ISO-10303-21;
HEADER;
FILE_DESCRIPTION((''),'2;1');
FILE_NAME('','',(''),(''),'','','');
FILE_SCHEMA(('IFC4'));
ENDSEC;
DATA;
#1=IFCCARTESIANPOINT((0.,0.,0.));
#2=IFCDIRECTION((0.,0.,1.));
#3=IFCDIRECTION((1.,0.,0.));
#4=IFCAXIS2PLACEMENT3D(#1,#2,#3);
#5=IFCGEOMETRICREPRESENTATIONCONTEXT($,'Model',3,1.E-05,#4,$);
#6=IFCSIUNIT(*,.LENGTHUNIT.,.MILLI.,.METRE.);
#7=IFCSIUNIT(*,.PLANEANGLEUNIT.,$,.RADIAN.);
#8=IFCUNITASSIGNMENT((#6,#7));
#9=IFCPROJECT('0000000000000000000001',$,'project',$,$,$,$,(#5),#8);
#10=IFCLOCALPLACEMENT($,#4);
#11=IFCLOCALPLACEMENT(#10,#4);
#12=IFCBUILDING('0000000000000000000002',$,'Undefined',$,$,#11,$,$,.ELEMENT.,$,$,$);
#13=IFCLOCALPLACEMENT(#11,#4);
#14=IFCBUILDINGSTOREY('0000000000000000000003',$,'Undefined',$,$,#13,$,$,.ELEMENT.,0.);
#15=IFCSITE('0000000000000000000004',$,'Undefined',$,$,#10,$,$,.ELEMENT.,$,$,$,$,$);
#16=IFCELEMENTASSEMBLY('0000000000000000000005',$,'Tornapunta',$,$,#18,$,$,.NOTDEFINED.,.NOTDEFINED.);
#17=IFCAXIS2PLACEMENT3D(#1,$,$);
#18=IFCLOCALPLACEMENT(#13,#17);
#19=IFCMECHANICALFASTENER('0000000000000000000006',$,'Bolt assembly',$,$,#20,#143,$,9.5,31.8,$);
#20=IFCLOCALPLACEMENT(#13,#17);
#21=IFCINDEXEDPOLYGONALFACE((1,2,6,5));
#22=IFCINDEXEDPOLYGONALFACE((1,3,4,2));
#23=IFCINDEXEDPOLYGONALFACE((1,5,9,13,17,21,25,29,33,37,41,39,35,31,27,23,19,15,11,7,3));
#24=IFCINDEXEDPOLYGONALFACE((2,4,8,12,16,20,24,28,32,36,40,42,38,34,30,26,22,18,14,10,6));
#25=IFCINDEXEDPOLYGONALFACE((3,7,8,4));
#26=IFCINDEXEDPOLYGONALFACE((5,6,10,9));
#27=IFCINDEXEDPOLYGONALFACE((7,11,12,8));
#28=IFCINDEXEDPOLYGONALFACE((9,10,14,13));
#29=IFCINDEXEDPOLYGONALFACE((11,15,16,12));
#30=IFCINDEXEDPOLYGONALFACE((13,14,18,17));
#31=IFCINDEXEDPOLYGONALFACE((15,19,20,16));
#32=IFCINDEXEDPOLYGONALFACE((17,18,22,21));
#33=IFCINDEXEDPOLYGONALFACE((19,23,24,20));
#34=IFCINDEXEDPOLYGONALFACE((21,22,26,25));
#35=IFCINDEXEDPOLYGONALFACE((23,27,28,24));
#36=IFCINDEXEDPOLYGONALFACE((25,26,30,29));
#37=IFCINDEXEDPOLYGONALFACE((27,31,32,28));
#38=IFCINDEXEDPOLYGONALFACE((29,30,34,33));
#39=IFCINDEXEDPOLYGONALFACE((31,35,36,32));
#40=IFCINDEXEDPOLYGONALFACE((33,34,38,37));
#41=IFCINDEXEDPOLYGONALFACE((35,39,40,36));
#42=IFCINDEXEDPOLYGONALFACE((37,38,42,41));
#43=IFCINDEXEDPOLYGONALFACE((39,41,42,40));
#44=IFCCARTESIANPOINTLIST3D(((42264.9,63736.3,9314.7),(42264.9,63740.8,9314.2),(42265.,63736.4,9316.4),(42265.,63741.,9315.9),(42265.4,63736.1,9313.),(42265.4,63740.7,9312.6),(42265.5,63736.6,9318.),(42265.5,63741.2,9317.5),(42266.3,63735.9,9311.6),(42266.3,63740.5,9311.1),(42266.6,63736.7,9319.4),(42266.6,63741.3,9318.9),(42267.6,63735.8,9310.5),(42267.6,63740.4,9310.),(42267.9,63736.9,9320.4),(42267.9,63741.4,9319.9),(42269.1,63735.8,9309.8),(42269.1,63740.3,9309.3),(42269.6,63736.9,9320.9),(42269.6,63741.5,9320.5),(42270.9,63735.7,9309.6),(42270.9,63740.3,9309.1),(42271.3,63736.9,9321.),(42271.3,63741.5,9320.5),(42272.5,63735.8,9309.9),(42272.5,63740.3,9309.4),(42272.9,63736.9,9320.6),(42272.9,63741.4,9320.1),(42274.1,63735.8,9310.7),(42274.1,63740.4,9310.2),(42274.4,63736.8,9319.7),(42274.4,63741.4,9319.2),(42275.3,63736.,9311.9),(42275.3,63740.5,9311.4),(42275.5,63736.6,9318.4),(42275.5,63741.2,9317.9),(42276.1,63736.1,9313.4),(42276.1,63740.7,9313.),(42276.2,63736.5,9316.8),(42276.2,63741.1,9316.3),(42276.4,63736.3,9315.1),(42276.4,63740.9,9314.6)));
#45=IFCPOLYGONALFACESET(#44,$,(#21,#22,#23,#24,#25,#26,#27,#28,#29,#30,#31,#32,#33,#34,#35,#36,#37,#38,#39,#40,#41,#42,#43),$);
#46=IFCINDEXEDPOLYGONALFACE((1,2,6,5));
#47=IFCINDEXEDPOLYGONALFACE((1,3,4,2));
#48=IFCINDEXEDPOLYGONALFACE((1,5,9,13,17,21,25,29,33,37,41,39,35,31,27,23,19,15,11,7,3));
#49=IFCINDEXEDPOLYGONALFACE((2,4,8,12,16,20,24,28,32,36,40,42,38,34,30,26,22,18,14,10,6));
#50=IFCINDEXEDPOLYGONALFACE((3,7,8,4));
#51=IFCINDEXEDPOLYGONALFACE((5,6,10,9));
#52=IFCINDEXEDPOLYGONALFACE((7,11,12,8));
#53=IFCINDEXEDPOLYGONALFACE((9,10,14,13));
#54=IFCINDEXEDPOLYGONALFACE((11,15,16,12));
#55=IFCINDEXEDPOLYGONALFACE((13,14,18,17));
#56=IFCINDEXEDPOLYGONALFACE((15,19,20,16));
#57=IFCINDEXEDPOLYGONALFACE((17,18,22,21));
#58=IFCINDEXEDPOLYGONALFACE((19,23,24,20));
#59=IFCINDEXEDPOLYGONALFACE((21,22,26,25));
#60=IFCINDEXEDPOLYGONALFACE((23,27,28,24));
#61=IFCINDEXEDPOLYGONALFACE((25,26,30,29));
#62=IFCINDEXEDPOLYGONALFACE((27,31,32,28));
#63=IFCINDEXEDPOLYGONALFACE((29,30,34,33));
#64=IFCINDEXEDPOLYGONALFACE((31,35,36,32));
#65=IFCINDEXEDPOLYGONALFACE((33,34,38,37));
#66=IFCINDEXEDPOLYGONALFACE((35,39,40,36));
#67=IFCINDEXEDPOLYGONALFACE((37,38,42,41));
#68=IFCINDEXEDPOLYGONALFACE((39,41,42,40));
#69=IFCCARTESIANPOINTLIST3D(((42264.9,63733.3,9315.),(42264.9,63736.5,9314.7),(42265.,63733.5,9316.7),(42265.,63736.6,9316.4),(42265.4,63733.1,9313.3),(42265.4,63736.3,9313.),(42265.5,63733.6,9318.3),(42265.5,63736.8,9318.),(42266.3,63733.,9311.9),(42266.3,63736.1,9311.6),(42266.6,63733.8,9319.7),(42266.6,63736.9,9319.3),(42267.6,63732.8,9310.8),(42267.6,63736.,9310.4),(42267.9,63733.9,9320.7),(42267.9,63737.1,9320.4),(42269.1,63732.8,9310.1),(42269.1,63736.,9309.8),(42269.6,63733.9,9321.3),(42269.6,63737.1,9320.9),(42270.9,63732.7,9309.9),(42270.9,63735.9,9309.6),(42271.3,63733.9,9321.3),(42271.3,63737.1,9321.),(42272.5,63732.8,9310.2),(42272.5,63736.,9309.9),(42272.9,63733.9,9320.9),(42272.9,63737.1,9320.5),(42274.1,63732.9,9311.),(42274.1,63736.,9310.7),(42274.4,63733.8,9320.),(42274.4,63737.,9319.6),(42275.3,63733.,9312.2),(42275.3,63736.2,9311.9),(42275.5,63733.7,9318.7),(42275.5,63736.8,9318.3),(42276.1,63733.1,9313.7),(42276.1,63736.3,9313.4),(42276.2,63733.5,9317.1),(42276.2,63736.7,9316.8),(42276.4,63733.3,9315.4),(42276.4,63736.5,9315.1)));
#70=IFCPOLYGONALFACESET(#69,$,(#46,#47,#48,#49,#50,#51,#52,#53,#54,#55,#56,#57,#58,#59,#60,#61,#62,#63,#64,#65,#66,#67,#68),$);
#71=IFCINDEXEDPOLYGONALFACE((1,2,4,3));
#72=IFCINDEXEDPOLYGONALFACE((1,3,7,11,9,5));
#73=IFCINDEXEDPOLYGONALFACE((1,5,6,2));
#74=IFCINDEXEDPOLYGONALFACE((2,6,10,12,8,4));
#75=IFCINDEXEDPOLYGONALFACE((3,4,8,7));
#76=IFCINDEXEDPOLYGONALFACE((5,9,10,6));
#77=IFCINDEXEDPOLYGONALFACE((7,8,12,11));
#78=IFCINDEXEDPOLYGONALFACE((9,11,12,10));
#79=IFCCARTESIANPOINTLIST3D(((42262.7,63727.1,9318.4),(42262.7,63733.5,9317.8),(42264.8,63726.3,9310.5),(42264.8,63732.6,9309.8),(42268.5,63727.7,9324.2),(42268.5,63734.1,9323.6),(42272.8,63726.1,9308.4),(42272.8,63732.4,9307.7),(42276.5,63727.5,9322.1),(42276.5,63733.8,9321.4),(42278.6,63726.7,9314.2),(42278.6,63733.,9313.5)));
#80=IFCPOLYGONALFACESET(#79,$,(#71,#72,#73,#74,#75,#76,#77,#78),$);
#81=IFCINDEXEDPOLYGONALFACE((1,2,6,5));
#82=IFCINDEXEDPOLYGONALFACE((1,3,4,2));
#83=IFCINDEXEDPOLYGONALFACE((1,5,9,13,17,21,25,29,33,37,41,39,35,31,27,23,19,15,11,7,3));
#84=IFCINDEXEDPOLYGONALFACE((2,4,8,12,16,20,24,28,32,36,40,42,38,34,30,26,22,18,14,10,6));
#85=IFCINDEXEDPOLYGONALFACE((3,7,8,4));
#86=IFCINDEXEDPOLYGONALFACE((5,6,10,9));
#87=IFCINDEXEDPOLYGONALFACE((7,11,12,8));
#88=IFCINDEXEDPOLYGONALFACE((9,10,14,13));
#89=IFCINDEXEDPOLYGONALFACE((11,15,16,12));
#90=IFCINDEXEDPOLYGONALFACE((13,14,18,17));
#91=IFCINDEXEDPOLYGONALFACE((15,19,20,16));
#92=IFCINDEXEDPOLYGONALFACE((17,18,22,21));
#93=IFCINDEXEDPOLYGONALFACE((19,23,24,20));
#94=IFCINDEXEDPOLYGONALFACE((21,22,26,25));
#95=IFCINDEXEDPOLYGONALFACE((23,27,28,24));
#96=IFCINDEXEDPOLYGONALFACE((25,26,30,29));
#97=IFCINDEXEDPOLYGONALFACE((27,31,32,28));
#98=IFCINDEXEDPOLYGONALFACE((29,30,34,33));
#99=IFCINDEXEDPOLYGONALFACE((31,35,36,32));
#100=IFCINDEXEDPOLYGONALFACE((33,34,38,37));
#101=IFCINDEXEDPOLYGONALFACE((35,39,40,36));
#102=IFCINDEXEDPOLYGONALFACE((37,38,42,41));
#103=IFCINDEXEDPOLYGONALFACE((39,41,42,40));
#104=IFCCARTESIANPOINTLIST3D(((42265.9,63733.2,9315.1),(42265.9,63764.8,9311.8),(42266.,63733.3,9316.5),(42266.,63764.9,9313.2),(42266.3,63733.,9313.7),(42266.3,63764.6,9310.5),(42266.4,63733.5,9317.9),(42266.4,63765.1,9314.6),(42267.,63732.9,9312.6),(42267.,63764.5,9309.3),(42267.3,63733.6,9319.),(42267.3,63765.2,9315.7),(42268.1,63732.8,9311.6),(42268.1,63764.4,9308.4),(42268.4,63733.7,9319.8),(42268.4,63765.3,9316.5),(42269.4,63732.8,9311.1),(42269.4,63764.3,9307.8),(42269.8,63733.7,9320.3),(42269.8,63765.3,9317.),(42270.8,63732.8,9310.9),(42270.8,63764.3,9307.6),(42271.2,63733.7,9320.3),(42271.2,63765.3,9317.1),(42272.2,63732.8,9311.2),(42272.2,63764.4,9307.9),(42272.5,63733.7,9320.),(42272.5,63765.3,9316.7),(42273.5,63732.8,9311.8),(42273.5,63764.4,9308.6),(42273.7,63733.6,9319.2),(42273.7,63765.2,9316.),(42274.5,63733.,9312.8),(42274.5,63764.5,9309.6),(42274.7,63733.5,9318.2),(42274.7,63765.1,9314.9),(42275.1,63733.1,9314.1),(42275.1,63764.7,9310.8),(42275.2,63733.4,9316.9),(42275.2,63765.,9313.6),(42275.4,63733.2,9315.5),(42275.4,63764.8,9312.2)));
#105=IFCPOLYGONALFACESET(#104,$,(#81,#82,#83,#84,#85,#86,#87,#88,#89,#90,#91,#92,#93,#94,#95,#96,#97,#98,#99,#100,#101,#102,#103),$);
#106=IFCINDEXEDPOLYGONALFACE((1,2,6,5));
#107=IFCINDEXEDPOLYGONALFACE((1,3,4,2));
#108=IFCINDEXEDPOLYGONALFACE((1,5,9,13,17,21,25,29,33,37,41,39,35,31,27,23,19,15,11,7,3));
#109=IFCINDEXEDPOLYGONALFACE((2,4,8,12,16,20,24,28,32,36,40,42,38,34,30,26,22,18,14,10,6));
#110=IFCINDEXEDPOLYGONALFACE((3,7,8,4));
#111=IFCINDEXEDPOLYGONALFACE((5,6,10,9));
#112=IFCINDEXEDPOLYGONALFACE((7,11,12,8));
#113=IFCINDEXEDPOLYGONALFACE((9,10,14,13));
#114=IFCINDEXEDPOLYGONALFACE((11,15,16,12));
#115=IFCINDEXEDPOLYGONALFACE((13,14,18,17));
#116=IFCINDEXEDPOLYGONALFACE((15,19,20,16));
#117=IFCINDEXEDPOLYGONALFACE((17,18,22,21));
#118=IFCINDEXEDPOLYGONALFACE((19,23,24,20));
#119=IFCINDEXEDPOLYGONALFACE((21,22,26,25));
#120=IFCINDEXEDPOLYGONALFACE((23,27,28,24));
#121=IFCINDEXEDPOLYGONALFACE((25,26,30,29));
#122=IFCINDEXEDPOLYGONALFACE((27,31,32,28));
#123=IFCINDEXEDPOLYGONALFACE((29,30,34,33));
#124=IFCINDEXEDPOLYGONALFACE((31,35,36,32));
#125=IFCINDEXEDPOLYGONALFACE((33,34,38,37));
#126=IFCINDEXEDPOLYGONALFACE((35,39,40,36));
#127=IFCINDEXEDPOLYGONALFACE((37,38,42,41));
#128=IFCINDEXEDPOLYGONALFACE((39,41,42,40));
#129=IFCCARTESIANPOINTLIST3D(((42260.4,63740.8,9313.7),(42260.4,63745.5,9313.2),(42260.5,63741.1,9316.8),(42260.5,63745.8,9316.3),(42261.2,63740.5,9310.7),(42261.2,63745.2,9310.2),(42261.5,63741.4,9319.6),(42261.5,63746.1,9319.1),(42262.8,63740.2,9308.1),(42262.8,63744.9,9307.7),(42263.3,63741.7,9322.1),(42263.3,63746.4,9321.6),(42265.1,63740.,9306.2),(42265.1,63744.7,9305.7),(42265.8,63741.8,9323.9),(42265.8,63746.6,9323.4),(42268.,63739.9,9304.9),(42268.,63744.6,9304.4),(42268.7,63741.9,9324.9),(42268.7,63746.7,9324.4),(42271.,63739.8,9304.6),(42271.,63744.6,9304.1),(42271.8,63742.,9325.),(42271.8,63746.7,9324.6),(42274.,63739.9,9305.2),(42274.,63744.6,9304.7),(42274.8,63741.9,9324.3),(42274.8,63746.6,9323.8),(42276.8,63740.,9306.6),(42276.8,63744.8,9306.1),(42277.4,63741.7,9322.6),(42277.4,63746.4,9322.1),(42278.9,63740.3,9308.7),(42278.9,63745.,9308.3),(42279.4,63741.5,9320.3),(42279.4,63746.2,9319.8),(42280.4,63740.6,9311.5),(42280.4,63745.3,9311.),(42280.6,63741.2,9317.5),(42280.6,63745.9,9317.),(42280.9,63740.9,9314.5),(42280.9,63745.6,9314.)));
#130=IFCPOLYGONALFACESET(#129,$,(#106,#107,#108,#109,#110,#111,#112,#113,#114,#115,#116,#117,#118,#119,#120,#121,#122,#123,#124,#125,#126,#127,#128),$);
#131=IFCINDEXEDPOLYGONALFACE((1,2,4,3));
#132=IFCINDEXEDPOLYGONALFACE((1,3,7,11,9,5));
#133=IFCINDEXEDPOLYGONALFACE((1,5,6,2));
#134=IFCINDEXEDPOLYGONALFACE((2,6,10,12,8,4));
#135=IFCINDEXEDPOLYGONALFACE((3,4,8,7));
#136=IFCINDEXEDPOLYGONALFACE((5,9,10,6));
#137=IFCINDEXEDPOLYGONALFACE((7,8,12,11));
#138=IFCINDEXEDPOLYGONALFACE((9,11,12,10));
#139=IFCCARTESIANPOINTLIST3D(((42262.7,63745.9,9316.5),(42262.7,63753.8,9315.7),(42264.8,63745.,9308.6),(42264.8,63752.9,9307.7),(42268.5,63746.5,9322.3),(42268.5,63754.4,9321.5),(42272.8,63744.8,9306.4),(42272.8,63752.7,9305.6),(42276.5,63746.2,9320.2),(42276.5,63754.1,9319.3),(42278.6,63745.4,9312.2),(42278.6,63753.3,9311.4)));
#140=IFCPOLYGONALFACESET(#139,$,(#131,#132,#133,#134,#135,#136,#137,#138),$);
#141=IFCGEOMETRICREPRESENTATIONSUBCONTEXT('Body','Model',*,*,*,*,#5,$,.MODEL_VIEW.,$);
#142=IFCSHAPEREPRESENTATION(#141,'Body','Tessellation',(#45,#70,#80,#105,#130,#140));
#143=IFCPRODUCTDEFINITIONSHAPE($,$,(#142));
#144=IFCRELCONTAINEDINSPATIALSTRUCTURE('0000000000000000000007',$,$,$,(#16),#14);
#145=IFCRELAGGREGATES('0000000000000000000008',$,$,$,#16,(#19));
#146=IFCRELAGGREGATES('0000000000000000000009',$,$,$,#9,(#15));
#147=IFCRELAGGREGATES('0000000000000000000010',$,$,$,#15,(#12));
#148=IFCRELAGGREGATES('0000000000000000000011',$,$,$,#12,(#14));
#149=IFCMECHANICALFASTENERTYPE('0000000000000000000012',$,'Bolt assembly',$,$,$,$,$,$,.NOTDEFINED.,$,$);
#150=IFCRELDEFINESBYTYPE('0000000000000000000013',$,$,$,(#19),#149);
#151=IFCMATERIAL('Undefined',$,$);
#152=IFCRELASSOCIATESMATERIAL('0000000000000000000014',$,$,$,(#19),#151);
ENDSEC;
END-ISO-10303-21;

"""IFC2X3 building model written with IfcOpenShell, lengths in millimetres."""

from ifc_helpers import new_model, si_unit, frame, origin_with_axes, origin_2d_with_axis, place, context, subcontext, project, spatial, polyline, circle, outline, extrude, source, transform, mapped, material, type_object, element, aggregate, save


model = new_model("IFC2X3")

# Units and contexts
model_context = context("Model", 3, precision=1e-05, world=origin_with_axes())
body_context = subcontext(model_context, "Body", "Model", "MODEL_VIEW")
ifc_project = project(units=[si_unit("LENGTHUNIT", "METRE", prefix="MILLI"), si_unit("PLANEANGLEUNIT", "RADIAN")], contexts=[model_context])

# Site, building, storey
site_placement = place(None, origin_with_axes())
site = spatial("IfcSite", under=ifc_project, at=site_placement, Name="Undefined", CompositionType="ELEMENT")
building_placement = place(site_placement, origin_with_axes())
building = spatial("IfcBuilding", under=site, at=building_placement, Name="Undefined", CompositionType="ELEMENT")
storey_placement = place(building_placement, origin_with_axes())
storey = spatial("IfcBuildingStorey", under=building, at=storey_placement, Name="Undefined", CompositionType="ELEMENT", Elevation=0.0)

# Element assembly
assembly_1_placement = place(storey_placement, origin_with_axes())
assembly_1 = element("IfcElementAssembly", 1, at=assembly_1_placement, inside=storey, Name="Tornapunta", AssemblyPlace="NOTDEFINED", PredefinedType="NOTDEFINED")

# Shared definitions
ifc_material_1 = material(Name="Undefined")
mechanical_fastener_type = type_object("IfcMechanicalFastenerType", Name="Bolt assembly")

# Mechanical fastener
shared_shape_1 = source(origin_with_axes(), body_context, "Body", "SweptSolid", [
    extrude(circle(Radius=5.8, at=origin_2d_with_axis()), frame((0.0, -0.1, 0.0), z_axis=(0.0, 1.0, 0.0), x_axis=(1.0, 0.0, 0.0)), (0.0, 0.0, 1.0), 4.6),
    extrude(circle(Radius=5.8, at=origin_2d_with_axis()), frame((0.0, -3.1, 0.0), z_axis=(0.0, 1.0, 0.0), x_axis=(1.0, 0.0, 0.0)), (0.0, 0.0, 1.0), 3.2),
    extrude(outline(polyline([(7.1, -4.1), (7.1, 4.1), (0.0, 8.2), (-7.1, 4.1), (-7.1, -4.1), (0.0, -8.2), (7.1, -4.1)])), frame((0.0, -9.5, 0.0), z_axis=(0.0, 1.0, 0.0), x_axis=(1.0, 0.0, 0.0)), (0.0, 0.0, 1.0), 6.3),
    extrude(circle(Radius=4.8, at=origin_2d_with_axis()), frame((0.0, -3.2, 0.0), z_axis=(0.0, 1.0, 0.0), x_axis=(1.0, 0.0, 0.0)), (0.0, 0.0, 1.0), 31.8),
    extrude(circle(Radius=10.3, at=origin_2d_with_axis()), frame((0.0, 4.5, 0.0), z_axis=(0.0, 1.0, 0.0), x_axis=(1.0, 0.0, 0.0)), (0.0, 0.0, 1.0), 4.8),
    extrude(outline(polyline([(7.1, -4.1), (7.1, 4.1), (0.0, 8.2), (-7.1, 4.1), (-7.1, -4.1), (0.0, -8.2), (7.1, -4.1)])), frame((0.0, 9.3, 0.0), z_axis=(0.0, 1.0, 0.0), x_axis=(1.0, 0.0, 0.0)), (0.0, 0.0, 1.0), 7.9),
])
mechanical_fastener_1_placement = place(assembly_1_placement, frame((42270.6, 63736.4, 9315.3), z_axis=(-0.707107, -0.072947, -0.703334), x_axis=(-0.707107, 0.072947, 0.703334)))
mechanical_fastener_1 = element("IfcMechanicalFastener", 2, at=mechanical_fastener_1_placement, type_object=mechanical_fastener_type, material=ifc_material_1, Name="Bolt assembly", NominalDiameter=9.5, NominalLength=31.8, context=body_context, shape_type="MappedRepresentation", body=[
    mapped(shared_shape_1, transform((0.0, 0.0, 0.0))),
])
aggregate(assembly_1, [mechanical_fastener_1])

save(model, "model.ifc")
